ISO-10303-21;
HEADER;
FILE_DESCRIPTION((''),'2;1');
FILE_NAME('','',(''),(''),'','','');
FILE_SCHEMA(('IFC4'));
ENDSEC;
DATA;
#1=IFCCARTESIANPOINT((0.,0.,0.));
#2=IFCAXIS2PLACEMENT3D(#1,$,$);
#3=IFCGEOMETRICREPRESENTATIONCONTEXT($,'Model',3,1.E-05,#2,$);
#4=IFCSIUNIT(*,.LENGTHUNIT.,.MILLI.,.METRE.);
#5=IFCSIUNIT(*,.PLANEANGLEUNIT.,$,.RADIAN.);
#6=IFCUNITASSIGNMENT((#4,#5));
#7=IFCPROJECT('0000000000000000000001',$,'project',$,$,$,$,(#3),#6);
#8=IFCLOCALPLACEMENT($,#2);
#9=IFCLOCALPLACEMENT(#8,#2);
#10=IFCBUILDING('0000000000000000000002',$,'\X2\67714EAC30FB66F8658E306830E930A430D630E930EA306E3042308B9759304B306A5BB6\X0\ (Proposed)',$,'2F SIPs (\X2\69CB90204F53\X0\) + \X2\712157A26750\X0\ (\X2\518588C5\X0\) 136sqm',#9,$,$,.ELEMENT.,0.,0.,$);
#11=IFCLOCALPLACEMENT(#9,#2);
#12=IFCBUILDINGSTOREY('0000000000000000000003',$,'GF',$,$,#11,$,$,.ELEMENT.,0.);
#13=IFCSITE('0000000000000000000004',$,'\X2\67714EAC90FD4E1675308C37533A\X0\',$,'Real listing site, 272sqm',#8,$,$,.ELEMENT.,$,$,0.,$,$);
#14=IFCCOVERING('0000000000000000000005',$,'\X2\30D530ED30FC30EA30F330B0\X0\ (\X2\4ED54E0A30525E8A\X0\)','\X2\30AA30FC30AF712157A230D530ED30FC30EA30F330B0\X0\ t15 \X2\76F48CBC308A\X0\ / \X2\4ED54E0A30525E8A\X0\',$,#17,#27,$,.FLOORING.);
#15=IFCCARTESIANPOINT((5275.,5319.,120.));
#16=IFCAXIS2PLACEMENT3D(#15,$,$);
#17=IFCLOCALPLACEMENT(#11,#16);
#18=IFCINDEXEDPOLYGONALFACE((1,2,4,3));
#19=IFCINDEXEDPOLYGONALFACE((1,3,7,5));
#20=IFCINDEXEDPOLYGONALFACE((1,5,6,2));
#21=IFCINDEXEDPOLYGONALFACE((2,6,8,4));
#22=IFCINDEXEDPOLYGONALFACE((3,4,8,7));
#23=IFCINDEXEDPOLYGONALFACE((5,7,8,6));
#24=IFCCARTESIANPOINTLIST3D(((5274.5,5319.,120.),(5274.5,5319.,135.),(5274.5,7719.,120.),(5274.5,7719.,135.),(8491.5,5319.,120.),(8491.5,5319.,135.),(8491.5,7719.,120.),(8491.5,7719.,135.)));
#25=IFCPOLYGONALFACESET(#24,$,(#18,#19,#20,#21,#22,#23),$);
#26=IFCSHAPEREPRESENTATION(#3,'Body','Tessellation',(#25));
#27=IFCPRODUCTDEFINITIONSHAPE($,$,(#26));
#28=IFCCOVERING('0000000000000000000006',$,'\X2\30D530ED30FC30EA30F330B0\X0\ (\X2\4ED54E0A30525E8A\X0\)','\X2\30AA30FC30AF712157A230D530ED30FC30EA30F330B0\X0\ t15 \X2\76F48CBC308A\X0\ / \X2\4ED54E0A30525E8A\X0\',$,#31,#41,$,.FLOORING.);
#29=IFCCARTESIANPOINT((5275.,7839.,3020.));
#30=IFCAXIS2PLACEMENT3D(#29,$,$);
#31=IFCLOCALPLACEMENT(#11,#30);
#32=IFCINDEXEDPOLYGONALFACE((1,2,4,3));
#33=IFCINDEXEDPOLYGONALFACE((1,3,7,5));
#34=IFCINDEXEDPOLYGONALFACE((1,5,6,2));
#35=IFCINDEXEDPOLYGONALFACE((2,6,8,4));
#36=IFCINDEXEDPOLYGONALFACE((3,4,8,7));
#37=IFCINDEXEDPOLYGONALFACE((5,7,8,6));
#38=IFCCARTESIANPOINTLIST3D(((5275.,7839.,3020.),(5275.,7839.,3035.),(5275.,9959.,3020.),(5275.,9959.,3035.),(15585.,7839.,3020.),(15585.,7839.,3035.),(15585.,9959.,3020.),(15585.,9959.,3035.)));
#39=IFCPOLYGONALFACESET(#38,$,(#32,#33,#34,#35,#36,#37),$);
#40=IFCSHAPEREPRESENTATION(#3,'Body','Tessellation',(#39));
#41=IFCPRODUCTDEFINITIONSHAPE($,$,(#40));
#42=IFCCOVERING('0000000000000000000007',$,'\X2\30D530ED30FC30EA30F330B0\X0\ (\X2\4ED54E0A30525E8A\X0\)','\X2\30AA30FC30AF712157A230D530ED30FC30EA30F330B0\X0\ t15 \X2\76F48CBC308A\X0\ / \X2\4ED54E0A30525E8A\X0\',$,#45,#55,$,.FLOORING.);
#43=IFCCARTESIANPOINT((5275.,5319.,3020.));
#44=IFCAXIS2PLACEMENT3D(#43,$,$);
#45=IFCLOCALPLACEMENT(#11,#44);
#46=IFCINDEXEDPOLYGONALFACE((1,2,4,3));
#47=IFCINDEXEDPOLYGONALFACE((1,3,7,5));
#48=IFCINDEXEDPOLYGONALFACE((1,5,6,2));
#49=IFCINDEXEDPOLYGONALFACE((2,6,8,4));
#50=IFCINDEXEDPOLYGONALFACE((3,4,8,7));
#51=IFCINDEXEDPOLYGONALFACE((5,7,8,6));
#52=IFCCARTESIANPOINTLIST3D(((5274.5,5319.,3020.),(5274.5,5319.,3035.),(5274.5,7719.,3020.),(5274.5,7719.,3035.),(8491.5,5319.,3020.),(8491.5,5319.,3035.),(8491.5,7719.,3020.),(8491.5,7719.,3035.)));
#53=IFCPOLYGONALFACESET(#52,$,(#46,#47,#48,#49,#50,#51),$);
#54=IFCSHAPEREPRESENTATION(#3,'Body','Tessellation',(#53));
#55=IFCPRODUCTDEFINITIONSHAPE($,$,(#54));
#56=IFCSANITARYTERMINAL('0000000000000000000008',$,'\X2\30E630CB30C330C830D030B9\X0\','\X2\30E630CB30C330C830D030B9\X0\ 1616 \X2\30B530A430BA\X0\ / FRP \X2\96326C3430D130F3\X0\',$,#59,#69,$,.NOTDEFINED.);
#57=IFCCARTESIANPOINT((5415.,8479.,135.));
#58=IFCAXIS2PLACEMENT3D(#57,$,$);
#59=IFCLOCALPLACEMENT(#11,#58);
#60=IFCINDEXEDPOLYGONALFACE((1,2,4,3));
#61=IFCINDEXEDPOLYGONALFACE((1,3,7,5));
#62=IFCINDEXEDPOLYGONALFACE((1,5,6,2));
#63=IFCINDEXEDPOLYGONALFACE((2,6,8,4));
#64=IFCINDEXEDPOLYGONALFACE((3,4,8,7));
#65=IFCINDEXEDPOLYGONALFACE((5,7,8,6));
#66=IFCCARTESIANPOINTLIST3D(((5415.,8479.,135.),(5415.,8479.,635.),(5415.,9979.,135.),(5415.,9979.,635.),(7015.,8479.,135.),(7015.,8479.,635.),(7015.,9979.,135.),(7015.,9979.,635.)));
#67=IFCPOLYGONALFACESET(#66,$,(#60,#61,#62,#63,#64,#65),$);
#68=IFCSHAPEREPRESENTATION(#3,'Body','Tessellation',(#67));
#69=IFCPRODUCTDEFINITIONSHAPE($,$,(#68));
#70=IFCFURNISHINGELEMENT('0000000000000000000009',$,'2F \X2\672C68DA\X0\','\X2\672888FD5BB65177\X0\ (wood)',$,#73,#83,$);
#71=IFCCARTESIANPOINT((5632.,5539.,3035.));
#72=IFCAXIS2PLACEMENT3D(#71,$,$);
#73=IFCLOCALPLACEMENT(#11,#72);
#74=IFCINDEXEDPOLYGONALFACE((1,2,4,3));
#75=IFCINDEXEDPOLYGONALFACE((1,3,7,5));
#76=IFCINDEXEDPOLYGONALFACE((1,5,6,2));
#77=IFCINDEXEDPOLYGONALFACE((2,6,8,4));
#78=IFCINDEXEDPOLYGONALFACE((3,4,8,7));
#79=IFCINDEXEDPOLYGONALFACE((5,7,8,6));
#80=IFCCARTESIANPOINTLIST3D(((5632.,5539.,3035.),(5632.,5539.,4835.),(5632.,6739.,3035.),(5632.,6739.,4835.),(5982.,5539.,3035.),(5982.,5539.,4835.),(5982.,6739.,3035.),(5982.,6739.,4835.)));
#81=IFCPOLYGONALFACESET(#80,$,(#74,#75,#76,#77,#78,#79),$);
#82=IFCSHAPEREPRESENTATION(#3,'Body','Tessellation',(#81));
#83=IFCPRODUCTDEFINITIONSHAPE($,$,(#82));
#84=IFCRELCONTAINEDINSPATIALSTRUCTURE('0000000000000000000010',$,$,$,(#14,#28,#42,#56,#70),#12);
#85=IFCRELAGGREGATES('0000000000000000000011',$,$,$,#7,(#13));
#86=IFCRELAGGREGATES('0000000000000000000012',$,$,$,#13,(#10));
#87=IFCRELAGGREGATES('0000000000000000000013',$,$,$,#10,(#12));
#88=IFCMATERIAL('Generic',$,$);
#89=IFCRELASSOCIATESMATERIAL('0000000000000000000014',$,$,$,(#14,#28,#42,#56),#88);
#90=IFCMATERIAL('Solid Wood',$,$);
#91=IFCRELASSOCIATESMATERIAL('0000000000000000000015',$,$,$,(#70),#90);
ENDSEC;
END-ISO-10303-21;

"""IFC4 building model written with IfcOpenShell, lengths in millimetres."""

from ifc_helpers import new_model, si_unit, frame, frame_2d, origin, place, context, project, spatial, rectangle, extrude, material, element, save


model = new_model("IFC4")

# Units and contexts
model_context = context("Model", 3, precision=1e-05, world=origin())
ifc_project = project(units=[si_unit("LENGTHUNIT", "METRE", prefix="MILLI"), si_unit("PLANEANGLEUNIT", "RADIAN")], contexts=[model_context])

# Site, building, storey
site_placement = place(None, origin())
site = spatial("IfcSite", under=ifc_project, at=site_placement, Name="東京都世田谷区", ObjectType="Real listing site, 272sqm", CompositionType="ELEMENT", RefElevation=0.0)
building_placement = place(site_placement, origin())
building = spatial("IfcBuilding", under=site, at=building_placement, Name="東京・書斎とライブラリのある静かな家 (Proposed)", ObjectType="2F SIPs (構造体) + 無垢材 (内装) 136sqm", CompositionType="ELEMENT", ElevationOfRefHeight=0.0, ElevationOfTerrain=0.0)
storey_placement = place(building_placement, origin())
storey = spatial("IfcBuildingStorey", under=building, at=storey_placement, Name="GF", CompositionType="ELEMENT", Elevation=0.0)

# Shared definitions
ifc_material_1 = material(Name="Solid Wood")

# Coverings
ifc_material_2 = material(Name="Generic")
covering_1_placement = place(storey_placement, frame((5275.0, 5319.0, 120.0)))
element("IfcCovering", 1, at=covering_1_placement, inside=storey, material=ifc_material_2, Name="フローリング (仕上げ床)", Description="オーク無垢フローリング t15 直貼り / 仕上げ床", PredefinedType="FLOORING", context=model_context, shape_type="SweptSolid", body=[
    extrude(rectangle(XDim=3217.0, YDim=2400.0, at=frame_2d((1608.0, 1200.0))), frame((5275.0, 5319.0, 120.0)), (0.0, 0.0, 1.0), 15.0),
])
covering_2_placement = place(storey_placement, frame((5275.0, 7839.0, 3020.0)))
element("IfcCovering", 2, at=covering_2_placement, inside=storey, material=ifc_material_2, Name="フローリング (仕上げ床)", Description="オーク無垢フローリング t15 直貼り / 仕上げ床", PredefinedType="FLOORING", context=model_context, shape_type="SweptSolid", body=[
    extrude(rectangle(XDim=10310.0, YDim=2120.0, at=frame_2d((5155.0, 1060.0))), frame((5275.0, 7839.0, 3020.0)), (0.0, 0.0, 1.0), 15.0),
])
covering_3_placement = place(storey_placement, frame((5275.0, 5319.0, 3020.0)))
element("IfcCovering", 3, at=covering_3_placement, inside=storey, material=ifc_material_2, Name="フローリング (仕上げ床)", Description="オーク無垢フローリング t15 直貼り / 仕上げ床", PredefinedType="FLOORING", context=model_context, shape_type="SweptSolid", body=[
    extrude(rectangle(XDim=3217.0, YDim=2400.0, at=frame_2d((1608.0, 1200.0))), frame((5275.0, 5319.0, 3020.0)), (0.0, 0.0, 1.0), 15.0),
])

# Sanitary terminal
sanitary_terminal_placement = place(storey_placement, frame((5415.0, 8479.0, 135.0)))
element("IfcSanitaryTerminal", 4, at=sanitary_terminal_placement, inside=storey, material=ifc_material_2, Name="ユニットバス", Description="ユニットバス 1616 サイズ / FRP 防水パン", PredefinedType="NOTDEFINED", context=model_context, shape_type="SweptSolid", body=[
    extrude(rectangle(XDim=1600.0, YDim=1500.0, at=frame_2d((800.0, 750.0))), frame((5415.0, 8479.0, 135.0)), (0.0, 0.0, 1.0), 500.0),
])

# Furnishing element
furnishing_placement = place(storey_placement, frame((5632.0, 5539.0, 3035.0)))
element("IfcFurnishingElement", 5, at=furnishing_placement, inside=storey, material=ifc_material_1, Name="2F 本棚", Description="木製家具 (wood)", context=model_context, shape_type="SweptSolid", body=[
    extrude(rectangle(XDim=350.0, YDim=1200.0, at=frame_2d((175.0, 600.0))), frame((5632.0, 5539.0, 3035.0)), (0.0, 0.0, 1.0), 1800.0),
])

save(model, "model.ifc")
